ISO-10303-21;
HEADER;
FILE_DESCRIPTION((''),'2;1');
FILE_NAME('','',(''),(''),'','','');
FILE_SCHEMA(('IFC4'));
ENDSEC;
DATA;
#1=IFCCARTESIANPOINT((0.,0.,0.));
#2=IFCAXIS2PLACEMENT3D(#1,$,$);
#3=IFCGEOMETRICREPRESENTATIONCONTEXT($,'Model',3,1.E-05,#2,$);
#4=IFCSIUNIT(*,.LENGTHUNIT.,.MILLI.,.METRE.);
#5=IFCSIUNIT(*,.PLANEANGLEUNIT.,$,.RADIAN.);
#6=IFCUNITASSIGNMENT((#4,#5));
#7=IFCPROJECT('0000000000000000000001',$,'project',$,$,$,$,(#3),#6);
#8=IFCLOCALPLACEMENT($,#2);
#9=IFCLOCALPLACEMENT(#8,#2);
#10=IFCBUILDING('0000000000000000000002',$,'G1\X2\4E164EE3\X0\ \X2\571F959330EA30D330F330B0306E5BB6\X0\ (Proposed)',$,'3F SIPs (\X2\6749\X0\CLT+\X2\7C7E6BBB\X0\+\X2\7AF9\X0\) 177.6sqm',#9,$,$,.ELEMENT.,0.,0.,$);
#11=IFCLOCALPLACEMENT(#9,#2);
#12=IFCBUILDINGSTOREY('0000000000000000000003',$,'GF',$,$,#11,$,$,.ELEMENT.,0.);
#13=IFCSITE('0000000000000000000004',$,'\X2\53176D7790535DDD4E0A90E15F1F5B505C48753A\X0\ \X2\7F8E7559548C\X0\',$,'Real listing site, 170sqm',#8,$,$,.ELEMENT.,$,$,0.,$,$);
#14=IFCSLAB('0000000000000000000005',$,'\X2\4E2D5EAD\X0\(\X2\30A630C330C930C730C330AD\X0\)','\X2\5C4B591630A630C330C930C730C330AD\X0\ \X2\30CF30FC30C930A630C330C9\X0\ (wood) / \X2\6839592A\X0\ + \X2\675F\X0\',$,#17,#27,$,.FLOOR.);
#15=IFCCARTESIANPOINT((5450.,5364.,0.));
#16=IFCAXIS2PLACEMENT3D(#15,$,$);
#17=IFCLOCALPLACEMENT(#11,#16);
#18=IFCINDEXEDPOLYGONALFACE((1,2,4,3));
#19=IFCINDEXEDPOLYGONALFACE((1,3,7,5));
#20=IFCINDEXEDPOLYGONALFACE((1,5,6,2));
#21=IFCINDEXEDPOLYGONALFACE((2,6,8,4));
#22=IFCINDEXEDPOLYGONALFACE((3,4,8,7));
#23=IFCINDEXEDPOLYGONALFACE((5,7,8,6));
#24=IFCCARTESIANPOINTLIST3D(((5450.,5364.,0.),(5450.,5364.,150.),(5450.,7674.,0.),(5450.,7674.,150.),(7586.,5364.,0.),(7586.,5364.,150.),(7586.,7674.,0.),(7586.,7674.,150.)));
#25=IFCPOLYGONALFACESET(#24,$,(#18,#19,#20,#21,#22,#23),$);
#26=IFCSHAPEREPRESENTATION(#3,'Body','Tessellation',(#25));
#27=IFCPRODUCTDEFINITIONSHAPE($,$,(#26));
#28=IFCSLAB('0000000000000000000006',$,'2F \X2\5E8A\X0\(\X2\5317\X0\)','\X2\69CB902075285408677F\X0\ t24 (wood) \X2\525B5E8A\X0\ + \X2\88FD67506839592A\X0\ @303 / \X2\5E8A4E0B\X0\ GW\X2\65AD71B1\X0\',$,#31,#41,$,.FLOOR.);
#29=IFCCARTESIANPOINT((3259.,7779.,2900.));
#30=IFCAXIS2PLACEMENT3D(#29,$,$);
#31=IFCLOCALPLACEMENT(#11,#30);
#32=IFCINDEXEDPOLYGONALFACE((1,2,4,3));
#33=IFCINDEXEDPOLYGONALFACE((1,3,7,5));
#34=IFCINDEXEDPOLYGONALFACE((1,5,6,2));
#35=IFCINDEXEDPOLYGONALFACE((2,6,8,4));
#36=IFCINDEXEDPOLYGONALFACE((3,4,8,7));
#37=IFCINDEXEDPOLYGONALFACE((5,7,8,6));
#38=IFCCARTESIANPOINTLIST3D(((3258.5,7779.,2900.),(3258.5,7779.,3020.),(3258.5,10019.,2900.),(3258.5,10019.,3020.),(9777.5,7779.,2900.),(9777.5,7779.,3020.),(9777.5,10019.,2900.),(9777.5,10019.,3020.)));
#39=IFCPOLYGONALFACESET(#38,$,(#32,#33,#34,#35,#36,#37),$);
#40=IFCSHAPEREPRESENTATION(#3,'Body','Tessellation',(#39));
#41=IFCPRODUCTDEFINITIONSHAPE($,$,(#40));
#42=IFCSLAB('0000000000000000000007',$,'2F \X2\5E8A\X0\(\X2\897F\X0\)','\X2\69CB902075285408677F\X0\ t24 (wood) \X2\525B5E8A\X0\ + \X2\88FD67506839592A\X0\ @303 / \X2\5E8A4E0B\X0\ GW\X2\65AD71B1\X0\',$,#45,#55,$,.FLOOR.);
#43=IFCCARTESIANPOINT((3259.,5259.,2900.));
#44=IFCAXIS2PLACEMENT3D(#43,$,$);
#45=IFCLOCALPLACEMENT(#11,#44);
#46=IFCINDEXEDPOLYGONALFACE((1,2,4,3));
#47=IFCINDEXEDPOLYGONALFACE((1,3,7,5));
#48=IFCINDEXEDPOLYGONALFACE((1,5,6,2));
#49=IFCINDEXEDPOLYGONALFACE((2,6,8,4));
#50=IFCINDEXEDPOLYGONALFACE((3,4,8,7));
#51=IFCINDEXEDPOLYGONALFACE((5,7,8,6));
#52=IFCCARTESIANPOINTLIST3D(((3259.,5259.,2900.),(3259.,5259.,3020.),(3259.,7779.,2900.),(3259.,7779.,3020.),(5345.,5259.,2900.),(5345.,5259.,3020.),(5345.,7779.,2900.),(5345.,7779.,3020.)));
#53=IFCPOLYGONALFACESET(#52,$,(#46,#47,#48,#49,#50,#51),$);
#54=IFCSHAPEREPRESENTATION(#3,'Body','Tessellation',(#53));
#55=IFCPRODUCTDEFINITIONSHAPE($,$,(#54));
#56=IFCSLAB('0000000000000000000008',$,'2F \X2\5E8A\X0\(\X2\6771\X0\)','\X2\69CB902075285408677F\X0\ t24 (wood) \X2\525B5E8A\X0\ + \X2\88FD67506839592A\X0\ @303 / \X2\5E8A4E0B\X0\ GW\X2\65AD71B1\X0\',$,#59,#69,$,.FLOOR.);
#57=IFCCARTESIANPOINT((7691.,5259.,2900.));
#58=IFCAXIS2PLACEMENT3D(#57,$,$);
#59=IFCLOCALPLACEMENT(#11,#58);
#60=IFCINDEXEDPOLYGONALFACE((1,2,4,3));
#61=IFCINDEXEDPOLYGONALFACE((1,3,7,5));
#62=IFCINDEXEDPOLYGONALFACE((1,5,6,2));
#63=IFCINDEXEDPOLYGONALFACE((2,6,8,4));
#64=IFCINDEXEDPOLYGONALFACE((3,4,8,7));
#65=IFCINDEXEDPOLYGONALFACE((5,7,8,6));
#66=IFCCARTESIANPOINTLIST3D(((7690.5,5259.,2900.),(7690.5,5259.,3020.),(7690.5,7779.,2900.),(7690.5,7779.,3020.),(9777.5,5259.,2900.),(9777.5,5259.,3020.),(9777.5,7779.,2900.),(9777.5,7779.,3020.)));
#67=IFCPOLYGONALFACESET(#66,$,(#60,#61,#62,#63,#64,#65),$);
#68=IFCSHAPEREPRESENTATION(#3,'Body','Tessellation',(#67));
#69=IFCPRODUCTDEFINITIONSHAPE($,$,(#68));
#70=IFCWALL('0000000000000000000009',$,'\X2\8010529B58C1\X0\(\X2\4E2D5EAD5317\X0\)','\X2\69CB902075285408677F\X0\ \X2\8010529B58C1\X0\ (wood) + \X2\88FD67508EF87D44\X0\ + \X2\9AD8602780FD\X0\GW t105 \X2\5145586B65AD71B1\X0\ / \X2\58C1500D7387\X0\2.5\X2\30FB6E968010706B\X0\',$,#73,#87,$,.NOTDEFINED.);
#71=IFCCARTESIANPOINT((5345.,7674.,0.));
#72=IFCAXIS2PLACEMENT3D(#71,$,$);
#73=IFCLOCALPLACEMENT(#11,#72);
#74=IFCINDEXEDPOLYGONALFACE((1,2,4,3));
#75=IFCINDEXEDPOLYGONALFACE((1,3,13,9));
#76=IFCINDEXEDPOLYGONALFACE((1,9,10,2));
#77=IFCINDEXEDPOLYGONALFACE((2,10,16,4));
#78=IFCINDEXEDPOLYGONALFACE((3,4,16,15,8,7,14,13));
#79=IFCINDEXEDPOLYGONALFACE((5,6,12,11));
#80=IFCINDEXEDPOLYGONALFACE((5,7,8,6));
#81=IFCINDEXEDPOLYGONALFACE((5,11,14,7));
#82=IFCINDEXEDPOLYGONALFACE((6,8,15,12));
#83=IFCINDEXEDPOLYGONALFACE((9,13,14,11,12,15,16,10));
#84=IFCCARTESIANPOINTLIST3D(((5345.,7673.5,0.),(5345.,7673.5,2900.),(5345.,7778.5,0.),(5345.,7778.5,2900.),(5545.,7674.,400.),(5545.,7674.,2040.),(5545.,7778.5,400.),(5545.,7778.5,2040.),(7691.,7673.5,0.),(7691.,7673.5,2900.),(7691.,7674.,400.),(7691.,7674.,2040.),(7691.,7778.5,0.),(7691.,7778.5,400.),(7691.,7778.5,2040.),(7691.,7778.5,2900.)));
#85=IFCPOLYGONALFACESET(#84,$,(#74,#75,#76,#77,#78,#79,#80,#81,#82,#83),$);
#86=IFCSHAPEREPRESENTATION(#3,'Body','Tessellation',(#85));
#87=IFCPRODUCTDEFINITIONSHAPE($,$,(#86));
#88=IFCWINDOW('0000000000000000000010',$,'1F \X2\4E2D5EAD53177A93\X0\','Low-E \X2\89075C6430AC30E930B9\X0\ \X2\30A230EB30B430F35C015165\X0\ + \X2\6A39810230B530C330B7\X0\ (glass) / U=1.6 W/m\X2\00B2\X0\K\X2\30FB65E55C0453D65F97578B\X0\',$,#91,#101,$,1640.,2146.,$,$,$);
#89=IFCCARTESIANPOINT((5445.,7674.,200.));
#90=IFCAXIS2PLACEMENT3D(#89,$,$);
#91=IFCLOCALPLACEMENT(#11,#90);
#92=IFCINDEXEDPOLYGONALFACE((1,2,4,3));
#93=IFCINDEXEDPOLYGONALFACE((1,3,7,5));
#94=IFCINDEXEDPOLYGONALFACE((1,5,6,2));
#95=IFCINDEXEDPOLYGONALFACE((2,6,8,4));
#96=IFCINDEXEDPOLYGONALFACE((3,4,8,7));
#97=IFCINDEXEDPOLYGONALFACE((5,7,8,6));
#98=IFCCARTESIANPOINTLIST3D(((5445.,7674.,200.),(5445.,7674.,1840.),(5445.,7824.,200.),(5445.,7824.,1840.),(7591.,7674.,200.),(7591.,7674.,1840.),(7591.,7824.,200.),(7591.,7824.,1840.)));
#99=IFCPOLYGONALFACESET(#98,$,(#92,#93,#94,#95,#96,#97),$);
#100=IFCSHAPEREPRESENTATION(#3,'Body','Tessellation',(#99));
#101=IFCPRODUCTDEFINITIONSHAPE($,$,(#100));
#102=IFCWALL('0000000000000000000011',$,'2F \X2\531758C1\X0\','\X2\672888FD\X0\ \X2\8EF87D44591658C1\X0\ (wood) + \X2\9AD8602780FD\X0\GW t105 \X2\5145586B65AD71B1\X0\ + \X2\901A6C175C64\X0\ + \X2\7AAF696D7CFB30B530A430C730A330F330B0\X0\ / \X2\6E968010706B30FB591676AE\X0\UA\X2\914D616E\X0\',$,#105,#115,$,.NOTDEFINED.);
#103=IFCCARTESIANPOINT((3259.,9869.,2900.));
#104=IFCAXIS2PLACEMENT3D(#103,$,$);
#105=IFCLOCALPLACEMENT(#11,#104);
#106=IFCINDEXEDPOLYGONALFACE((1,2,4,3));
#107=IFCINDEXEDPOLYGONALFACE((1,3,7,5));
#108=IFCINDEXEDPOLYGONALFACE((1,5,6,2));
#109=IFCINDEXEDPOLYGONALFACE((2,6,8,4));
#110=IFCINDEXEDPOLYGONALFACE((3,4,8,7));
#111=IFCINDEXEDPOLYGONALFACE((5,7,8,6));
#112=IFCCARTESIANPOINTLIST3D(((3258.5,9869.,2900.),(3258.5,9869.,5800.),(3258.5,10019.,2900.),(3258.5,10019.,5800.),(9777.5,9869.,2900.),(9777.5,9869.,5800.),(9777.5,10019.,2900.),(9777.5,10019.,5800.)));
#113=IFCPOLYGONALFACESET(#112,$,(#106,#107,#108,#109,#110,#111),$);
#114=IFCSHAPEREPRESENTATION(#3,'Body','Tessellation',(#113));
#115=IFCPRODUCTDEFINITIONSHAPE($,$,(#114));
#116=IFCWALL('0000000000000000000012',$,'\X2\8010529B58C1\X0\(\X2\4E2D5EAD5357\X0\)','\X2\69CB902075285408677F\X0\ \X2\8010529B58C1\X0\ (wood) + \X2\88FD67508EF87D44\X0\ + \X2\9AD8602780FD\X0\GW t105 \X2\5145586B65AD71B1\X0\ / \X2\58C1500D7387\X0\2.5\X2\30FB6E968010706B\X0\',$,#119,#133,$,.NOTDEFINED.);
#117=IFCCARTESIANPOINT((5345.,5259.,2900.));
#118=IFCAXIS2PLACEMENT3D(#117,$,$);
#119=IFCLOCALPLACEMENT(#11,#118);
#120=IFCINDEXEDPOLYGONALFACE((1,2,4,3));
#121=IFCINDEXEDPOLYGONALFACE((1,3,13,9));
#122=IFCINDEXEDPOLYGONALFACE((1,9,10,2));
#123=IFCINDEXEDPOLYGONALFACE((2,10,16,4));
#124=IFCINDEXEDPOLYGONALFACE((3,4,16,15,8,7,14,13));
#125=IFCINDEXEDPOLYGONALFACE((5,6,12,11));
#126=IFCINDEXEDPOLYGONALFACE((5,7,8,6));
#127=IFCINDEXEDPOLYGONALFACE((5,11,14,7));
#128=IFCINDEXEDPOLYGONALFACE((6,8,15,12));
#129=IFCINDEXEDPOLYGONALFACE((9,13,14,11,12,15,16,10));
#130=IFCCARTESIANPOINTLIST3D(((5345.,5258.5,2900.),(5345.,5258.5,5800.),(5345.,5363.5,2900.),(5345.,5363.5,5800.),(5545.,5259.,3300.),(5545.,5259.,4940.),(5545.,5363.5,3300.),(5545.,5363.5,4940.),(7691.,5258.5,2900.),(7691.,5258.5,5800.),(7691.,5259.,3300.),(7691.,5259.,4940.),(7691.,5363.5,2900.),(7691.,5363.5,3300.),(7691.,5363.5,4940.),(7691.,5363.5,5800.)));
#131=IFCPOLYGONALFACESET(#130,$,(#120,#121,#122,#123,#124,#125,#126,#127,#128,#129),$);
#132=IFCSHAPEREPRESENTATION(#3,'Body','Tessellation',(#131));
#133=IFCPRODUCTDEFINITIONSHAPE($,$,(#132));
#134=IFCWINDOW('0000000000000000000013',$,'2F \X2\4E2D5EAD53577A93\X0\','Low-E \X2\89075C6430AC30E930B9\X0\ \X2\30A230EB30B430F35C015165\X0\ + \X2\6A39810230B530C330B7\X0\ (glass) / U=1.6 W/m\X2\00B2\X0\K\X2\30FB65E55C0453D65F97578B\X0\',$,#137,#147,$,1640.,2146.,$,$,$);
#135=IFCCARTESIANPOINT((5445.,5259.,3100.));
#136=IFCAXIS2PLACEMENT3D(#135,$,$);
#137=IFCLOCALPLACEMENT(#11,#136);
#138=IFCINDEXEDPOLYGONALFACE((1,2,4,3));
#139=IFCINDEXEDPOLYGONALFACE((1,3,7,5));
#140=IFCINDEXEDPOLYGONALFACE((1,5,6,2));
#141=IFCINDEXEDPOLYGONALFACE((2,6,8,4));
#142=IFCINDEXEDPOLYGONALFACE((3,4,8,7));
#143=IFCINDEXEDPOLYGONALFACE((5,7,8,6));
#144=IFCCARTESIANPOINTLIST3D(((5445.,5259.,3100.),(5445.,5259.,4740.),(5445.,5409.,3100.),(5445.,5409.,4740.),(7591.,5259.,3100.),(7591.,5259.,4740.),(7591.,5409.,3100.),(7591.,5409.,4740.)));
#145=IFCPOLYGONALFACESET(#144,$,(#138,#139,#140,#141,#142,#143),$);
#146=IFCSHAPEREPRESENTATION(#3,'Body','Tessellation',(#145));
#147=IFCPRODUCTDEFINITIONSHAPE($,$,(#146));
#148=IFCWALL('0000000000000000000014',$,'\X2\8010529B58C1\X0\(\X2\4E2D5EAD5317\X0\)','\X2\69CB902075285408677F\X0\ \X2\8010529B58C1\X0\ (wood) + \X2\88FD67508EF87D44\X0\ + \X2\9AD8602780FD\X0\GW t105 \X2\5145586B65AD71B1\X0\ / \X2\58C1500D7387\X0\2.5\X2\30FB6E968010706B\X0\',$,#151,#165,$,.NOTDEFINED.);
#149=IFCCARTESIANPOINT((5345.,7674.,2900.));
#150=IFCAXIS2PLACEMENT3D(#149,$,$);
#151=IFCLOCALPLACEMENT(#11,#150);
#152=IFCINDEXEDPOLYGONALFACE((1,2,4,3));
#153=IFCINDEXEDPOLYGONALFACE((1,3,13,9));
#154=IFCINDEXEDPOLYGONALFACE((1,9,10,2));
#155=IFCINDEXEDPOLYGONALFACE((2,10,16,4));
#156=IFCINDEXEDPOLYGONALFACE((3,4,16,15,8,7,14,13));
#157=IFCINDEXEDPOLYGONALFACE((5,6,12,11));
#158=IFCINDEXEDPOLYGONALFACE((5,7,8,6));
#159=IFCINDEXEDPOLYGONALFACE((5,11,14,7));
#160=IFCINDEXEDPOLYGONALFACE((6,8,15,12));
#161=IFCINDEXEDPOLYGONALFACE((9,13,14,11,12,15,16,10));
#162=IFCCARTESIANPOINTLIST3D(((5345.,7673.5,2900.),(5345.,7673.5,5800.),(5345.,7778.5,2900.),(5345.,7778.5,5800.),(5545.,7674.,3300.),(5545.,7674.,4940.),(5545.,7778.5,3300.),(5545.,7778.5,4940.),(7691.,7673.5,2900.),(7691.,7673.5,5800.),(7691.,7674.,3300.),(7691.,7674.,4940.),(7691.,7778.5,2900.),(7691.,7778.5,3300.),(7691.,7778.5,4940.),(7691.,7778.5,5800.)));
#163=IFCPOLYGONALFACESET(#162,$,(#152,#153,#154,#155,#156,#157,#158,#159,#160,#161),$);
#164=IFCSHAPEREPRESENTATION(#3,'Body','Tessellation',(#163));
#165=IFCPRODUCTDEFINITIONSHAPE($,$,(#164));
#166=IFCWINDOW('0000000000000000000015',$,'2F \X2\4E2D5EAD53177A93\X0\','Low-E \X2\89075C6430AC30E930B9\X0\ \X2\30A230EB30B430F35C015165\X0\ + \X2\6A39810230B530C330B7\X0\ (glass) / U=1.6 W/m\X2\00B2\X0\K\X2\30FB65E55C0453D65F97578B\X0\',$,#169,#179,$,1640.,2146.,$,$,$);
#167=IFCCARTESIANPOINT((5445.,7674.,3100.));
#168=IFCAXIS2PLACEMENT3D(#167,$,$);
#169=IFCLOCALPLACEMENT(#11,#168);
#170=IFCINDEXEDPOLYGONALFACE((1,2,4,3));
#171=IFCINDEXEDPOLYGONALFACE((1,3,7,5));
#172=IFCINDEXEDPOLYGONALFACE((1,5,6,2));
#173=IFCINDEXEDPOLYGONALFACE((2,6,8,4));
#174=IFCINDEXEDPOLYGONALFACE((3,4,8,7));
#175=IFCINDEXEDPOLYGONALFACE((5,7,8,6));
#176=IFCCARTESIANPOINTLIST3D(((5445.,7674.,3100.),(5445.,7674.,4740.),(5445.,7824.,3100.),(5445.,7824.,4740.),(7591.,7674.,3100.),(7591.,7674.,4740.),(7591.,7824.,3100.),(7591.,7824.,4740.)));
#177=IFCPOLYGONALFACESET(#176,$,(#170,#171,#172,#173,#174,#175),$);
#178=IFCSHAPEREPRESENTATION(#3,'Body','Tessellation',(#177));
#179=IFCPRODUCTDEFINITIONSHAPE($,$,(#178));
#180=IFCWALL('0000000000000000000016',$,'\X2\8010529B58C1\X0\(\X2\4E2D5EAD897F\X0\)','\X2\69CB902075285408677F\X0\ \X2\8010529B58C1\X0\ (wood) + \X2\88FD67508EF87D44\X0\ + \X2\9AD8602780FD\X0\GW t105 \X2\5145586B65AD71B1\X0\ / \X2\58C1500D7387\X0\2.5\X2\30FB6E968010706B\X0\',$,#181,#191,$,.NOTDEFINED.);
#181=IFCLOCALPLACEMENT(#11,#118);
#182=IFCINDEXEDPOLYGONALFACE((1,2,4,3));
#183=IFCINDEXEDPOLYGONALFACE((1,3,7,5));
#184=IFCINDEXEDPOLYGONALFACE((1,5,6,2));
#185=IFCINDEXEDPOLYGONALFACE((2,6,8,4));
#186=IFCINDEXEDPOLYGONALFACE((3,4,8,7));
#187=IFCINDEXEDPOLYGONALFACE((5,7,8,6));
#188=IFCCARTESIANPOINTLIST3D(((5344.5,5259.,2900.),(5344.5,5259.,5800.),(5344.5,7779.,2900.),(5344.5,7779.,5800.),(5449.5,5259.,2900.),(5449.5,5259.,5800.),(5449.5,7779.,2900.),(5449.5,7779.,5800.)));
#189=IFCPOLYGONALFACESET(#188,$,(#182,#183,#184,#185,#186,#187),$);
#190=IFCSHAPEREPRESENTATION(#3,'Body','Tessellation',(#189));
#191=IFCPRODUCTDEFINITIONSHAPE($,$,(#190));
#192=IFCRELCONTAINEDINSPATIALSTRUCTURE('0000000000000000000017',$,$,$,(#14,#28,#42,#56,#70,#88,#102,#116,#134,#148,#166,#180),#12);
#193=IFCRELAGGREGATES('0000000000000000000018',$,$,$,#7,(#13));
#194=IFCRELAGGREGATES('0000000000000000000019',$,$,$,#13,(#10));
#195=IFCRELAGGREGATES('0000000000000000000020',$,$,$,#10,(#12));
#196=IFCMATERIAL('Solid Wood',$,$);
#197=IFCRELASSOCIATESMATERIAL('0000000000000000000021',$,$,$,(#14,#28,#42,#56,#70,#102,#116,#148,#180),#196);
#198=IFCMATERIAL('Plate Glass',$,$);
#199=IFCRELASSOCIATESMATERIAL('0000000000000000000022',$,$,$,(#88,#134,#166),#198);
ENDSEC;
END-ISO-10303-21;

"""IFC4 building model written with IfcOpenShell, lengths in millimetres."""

from ifc_helpers import new_model, si_unit, frame, frame_2d, origin, place, context, project, spatial, rectangle, extrude, material, element, fill, save


model = new_model("IFC4")

# Units and contexts
model_context = context("Model", 3, precision=1e-05, world=origin())
ifc_project = project(units=[si_unit("LENGTHUNIT", "METRE", prefix="MILLI"), si_unit("PLANEANGLEUNIT", "RADIAN")], contexts=[model_context])

# Site, building, storey
site_placement = place(None, origin())
site = spatial("IfcSite", under=ifc_project, at=site_placement, Name="北海道川上郡弟子屈町 美留和", ObjectType="Real listing site, 170sqm", CompositionType="ELEMENT", RefElevation=0.0)
building_placement = place(site_placement, origin())
building = spatial("IfcBuilding", under=site, at=building_placement, Name="G1世代 土間リビングの家 (Proposed)", ObjectType="3F SIPs (杉CLT+籾殻+竹) 177.6sqm", CompositionType="ELEMENT", ElevationOfRefHeight=0.0, ElevationOfTerrain=0.0)
storey_placement = place(building_placement, origin())
storey = spatial("IfcBuildingStorey", under=building, at=storey_placement, Name="GF", CompositionType="ELEMENT", Elevation=0.0)

# Slabs
ifc_material_1 = material(Name="Solid Wood")
slab_1_placement = place(storey_placement, frame((5450.0, 5364.0, 0.0)))
element("IfcSlab", 1, at=slab_1_placement, inside=storey, material=ifc_material_1, Name="中庭(ウッドデッキ)", Description="屋外ウッドデッキ ハードウッド (wood) / 根太 + 束", PredefinedType="FLOOR", context=model_context, shape_type="SweptSolid", body=[
    extrude(rectangle(XDim=2136.0, YDim=2310.0, at=frame_2d((1068.0, 1155.0))), frame((5450.0, 5364.0, 0.0)), (0.0, 0.0, 1.0), 150.0),
])
slab_2_placement = place(storey_placement, frame((3259.0, 7779.0, 2900.0)))
element("IfcSlab", 2, at=slab_2_placement, inside=storey, material=ifc_material_1, Name="2F 床(北)", Description="構造用合板 t24 (wood) 剛床 + 製材根太 @303 / 床下 GW断熱", PredefinedType="FLOOR", context=model_context, shape_type="SweptSolid", body=[
    extrude(rectangle(XDim=6519.0, YDim=2240.0, at=frame_2d((3259.0, 1120.0))), frame((3259.0, 7779.0, 2900.0)), (0.0, 0.0, 1.0), 120.0),
])
slab_3_placement = place(storey_placement, frame((3259.0, 5259.0, 2900.0)))
element("IfcSlab", 3, at=slab_3_placement, inside=storey, material=ifc_material_1, Name="2F 床(西)", Description="構造用合板 t24 (wood) 剛床 + 製材根太 @303 / 床下 GW断熱", PredefinedType="FLOOR", context=model_context, shape_type="SweptSolid", body=[
    extrude(rectangle(XDim=2086.0, YDim=2520.0, at=frame_2d((1043.0, 1260.0))), frame((3259.0, 5259.0, 2900.0)), (0.0, 0.0, 1.0), 120.0),
])
slab_4_placement = place(storey_placement, frame((7691.0, 5259.0, 2900.0)))
element("IfcSlab", 4, at=slab_4_placement, inside=storey, material=ifc_material_1, Name="2F 床(東)", Description="構造用合板 t24 (wood) 剛床 + 製材根太 @303 / 床下 GW断熱", PredefinedType="FLOOR", context=model_context, shape_type="SweptSolid", body=[
    extrude(rectangle(XDim=2087.0, YDim=2520.0, at=frame_2d((1043.0, 1260.0))), frame((7691.0, 5259.0, 2900.0)), (0.0, 0.0, 1.0), 120.0),
])

# Wall, opening, window
wall_1_placement = place(storey_placement, frame((5345.0, 7674.0, 0.0)))
wall_1 = element("IfcWall", 5, at=wall_1_placement, inside=storey, material=ifc_material_1, Name="耐力壁(中庭北)", Description="構造用合板 耐力壁 (wood) + 製材軸組 + 高性能GW t105 充填断熱 / 壁倍率2.5・準耐火", PredefinedType="NOTDEFINED", context=model_context, shape_type="SweptSolid", body=[
    extrude(rectangle(XDim=2346.0, YDim=105.0, at=frame_2d((1173.0, 52.0))), frame((5345.0, 7674.0, 0.0)), (0.0, 0.0, 1.0), 2900.0),
])
opening_1_placement = place(storey_placement, frame((5445.0, 7674.0, 200.0)))
opening_1 = element("IfcOpeningElement", 6, at=opening_1_placement, cuts=wall_1, PredefinedType="NOTDEFINED", context=model_context, shape_type="SweptSolid", body=[
    extrude(rectangle(XDim=2146.0, YDim=150.0, at=frame_2d((1073.0, 75.0))), frame((5445.0, 7674.0, 200.0)), (0.0, 0.0, 1.0), 1640.0),
])
ifc_material_2 = material(Name="Plate Glass")
window_1_placement = place(storey_placement, frame((5445.0, 7674.0, 200.0)))
window_1 = element("IfcWindow", 7, at=window_1_placement, inside=storey, material=ifc_material_2, Name="1F 中庭北窓", Description="Low-E 複層ガラス アルゴン封入 + 樹脂サッシ (glass) / U=1.6 W/m²K・日射取得型", OverallHeight=1640.0, OverallWidth=2146.0, context=model_context, shape_type="SweptSolid", body=[
    extrude(rectangle(XDim=2146.0, YDim=150.0, at=frame_2d((1073.0, 75.0))), frame((5445.0, 7674.0, 200.0)), (0.0, 0.0, 1.0), 1640.0),
])
fill(opening_1, window_1)

# Wall
wall_2_placement = place(storey_placement, frame((3259.0, 9869.0, 2900.0)))
element("IfcWall", 8, at=wall_2_placement, inside=storey, material=ifc_material_1, Name="2F 北壁", Description="木製 軸組外壁 (wood) + 高性能GW t105 充填断熱 + 通気層 + 窯業系サイディング / 準耐火・外皮UA配慮", PredefinedType="NOTDEFINED", context=model_context, shape_type="SweptSolid", body=[
    extrude(rectangle(XDim=6519.0, YDim=150.0, at=frame_2d((3259.0, 75.0))), frame((3259.0, 9869.0, 2900.0)), (0.0, 0.0, 1.0), 2900.0),
])

# Walls, openings, windows
wall_3_placement = place(storey_placement, frame((5345.0, 5259.0, 2900.0)))
wall_3 = element("IfcWall", 9, at=wall_3_placement, inside=storey, material=ifc_material_1, Name="耐力壁(中庭南)", Description="構造用合板 耐力壁 (wood) + 製材軸組 + 高性能GW t105 充填断熱 / 壁倍率2.5・準耐火", PredefinedType="NOTDEFINED", context=model_context, shape_type="SweptSolid", body=[
    extrude(rectangle(XDim=2346.0, YDim=105.0, at=frame_2d((1173.0, 52.0))), frame((5345.0, 5259.0, 2900.0)), (0.0, 0.0, 1.0), 2900.0),
])
opening_2_placement = place(storey_placement, frame((5445.0, 5259.0, 3100.0)))
opening_2 = element("IfcOpeningElement", 10, at=opening_2_placement, cuts=wall_3, PredefinedType="NOTDEFINED", context=model_context, shape_type="SweptSolid", body=[
    extrude(rectangle(XDim=2146.0, YDim=150.0, at=frame_2d((1073.0, 75.0))), frame((5445.0, 5259.0, 3100.0)), (0.0, 0.0, 1.0), 1640.0),
])
window_2_placement = place(storey_placement, frame((5445.0, 5259.0, 3100.0)))
window_2 = element("IfcWindow", 11, at=window_2_placement, inside=storey, material=ifc_material_2, Name="2F 中庭南窓", Description="Low-E 複層ガラス アルゴン封入 + 樹脂サッシ (glass) / U=1.6 W/m²K・日射取得型", OverallHeight=1640.0, OverallWidth=2146.0, context=model_context, shape_type="SweptSolid", body=[
    extrude(rectangle(XDim=2146.0, YDim=150.0, at=frame_2d((1073.0, 75.0))), frame((5445.0, 5259.0, 3100.0)), (0.0, 0.0, 1.0), 1640.0),
])
fill(opening_2, window_2)
wall_4_placement = place(storey_placement, frame((5345.0, 7674.0, 2900.0)))
wall_4 = element("IfcWall", 12, at=wall_4_placement, inside=storey, material=ifc_material_1, Name="耐力壁(中庭北)", Description="構造用合板 耐力壁 (wood) + 製材軸組 + 高性能GW t105 充填断熱 / 壁倍率2.5・準耐火", PredefinedType="NOTDEFINED", context=model_context, shape_type="SweptSolid", body=[
    extrude(rectangle(XDim=2346.0, YDim=105.0, at=frame_2d((1173.0, 52.0))), frame((5345.0, 7674.0, 2900.0)), (0.0, 0.0, 1.0), 2900.0),
])
opening_3_placement = place(storey_placement, frame((5445.0, 7674.0, 3100.0)))
opening_3 = element("IfcOpeningElement", 13, at=opening_3_placement, cuts=wall_4, PredefinedType="NOTDEFINED", context=model_context, shape_type="SweptSolid", body=[
    extrude(rectangle(XDim=2146.0, YDim=150.0, at=frame_2d((1073.0, 75.0))), frame((5445.0, 7674.0, 3100.0)), (0.0, 0.0, 1.0), 1640.0),
])
window_3_placement = place(storey_placement, frame((5445.0, 7674.0, 3100.0)))
window_3 = element("IfcWindow", 14, at=window_3_placement, inside=storey, material=ifc_material_2, Name="2F 中庭北窓", Description="Low-E 複層ガラス アルゴン封入 + 樹脂サッシ (glass) / U=1.6 W/m²K・日射取得型", OverallHeight=1640.0, OverallWidth=2146.0, context=model_context, shape_type="SweptSolid", body=[
    extrude(rectangle(XDim=2146.0, YDim=150.0, at=frame_2d((1073.0, 75.0))), frame((5445.0, 7674.0, 3100.0)), (0.0, 0.0, 1.0), 1640.0),
])
fill(opening_3, window_3)

# Wall
wall_5_placement = place(storey_placement, frame((5345.0, 5259.0, 2900.0)))
element("IfcWall", 15, at=wall_5_placement, inside=storey, material=ifc_material_1, Name="耐力壁(中庭西)", Description="構造用合板 耐力壁 (wood) + 製材軸組 + 高性能GW t105 充填断熱 / 壁倍率2.5・準耐火", PredefinedType="NOTDEFINED", context=model_context, shape_type="SweptSolid", body=[
    extrude(rectangle(XDim=105.0, YDim=2520.0, at=frame_2d((52.0, 1260.0))), frame((5345.0, 5259.0, 2900.0)), (0.0, 0.0, 1.0), 2900.0),
])

save(model, "model.ifc")
